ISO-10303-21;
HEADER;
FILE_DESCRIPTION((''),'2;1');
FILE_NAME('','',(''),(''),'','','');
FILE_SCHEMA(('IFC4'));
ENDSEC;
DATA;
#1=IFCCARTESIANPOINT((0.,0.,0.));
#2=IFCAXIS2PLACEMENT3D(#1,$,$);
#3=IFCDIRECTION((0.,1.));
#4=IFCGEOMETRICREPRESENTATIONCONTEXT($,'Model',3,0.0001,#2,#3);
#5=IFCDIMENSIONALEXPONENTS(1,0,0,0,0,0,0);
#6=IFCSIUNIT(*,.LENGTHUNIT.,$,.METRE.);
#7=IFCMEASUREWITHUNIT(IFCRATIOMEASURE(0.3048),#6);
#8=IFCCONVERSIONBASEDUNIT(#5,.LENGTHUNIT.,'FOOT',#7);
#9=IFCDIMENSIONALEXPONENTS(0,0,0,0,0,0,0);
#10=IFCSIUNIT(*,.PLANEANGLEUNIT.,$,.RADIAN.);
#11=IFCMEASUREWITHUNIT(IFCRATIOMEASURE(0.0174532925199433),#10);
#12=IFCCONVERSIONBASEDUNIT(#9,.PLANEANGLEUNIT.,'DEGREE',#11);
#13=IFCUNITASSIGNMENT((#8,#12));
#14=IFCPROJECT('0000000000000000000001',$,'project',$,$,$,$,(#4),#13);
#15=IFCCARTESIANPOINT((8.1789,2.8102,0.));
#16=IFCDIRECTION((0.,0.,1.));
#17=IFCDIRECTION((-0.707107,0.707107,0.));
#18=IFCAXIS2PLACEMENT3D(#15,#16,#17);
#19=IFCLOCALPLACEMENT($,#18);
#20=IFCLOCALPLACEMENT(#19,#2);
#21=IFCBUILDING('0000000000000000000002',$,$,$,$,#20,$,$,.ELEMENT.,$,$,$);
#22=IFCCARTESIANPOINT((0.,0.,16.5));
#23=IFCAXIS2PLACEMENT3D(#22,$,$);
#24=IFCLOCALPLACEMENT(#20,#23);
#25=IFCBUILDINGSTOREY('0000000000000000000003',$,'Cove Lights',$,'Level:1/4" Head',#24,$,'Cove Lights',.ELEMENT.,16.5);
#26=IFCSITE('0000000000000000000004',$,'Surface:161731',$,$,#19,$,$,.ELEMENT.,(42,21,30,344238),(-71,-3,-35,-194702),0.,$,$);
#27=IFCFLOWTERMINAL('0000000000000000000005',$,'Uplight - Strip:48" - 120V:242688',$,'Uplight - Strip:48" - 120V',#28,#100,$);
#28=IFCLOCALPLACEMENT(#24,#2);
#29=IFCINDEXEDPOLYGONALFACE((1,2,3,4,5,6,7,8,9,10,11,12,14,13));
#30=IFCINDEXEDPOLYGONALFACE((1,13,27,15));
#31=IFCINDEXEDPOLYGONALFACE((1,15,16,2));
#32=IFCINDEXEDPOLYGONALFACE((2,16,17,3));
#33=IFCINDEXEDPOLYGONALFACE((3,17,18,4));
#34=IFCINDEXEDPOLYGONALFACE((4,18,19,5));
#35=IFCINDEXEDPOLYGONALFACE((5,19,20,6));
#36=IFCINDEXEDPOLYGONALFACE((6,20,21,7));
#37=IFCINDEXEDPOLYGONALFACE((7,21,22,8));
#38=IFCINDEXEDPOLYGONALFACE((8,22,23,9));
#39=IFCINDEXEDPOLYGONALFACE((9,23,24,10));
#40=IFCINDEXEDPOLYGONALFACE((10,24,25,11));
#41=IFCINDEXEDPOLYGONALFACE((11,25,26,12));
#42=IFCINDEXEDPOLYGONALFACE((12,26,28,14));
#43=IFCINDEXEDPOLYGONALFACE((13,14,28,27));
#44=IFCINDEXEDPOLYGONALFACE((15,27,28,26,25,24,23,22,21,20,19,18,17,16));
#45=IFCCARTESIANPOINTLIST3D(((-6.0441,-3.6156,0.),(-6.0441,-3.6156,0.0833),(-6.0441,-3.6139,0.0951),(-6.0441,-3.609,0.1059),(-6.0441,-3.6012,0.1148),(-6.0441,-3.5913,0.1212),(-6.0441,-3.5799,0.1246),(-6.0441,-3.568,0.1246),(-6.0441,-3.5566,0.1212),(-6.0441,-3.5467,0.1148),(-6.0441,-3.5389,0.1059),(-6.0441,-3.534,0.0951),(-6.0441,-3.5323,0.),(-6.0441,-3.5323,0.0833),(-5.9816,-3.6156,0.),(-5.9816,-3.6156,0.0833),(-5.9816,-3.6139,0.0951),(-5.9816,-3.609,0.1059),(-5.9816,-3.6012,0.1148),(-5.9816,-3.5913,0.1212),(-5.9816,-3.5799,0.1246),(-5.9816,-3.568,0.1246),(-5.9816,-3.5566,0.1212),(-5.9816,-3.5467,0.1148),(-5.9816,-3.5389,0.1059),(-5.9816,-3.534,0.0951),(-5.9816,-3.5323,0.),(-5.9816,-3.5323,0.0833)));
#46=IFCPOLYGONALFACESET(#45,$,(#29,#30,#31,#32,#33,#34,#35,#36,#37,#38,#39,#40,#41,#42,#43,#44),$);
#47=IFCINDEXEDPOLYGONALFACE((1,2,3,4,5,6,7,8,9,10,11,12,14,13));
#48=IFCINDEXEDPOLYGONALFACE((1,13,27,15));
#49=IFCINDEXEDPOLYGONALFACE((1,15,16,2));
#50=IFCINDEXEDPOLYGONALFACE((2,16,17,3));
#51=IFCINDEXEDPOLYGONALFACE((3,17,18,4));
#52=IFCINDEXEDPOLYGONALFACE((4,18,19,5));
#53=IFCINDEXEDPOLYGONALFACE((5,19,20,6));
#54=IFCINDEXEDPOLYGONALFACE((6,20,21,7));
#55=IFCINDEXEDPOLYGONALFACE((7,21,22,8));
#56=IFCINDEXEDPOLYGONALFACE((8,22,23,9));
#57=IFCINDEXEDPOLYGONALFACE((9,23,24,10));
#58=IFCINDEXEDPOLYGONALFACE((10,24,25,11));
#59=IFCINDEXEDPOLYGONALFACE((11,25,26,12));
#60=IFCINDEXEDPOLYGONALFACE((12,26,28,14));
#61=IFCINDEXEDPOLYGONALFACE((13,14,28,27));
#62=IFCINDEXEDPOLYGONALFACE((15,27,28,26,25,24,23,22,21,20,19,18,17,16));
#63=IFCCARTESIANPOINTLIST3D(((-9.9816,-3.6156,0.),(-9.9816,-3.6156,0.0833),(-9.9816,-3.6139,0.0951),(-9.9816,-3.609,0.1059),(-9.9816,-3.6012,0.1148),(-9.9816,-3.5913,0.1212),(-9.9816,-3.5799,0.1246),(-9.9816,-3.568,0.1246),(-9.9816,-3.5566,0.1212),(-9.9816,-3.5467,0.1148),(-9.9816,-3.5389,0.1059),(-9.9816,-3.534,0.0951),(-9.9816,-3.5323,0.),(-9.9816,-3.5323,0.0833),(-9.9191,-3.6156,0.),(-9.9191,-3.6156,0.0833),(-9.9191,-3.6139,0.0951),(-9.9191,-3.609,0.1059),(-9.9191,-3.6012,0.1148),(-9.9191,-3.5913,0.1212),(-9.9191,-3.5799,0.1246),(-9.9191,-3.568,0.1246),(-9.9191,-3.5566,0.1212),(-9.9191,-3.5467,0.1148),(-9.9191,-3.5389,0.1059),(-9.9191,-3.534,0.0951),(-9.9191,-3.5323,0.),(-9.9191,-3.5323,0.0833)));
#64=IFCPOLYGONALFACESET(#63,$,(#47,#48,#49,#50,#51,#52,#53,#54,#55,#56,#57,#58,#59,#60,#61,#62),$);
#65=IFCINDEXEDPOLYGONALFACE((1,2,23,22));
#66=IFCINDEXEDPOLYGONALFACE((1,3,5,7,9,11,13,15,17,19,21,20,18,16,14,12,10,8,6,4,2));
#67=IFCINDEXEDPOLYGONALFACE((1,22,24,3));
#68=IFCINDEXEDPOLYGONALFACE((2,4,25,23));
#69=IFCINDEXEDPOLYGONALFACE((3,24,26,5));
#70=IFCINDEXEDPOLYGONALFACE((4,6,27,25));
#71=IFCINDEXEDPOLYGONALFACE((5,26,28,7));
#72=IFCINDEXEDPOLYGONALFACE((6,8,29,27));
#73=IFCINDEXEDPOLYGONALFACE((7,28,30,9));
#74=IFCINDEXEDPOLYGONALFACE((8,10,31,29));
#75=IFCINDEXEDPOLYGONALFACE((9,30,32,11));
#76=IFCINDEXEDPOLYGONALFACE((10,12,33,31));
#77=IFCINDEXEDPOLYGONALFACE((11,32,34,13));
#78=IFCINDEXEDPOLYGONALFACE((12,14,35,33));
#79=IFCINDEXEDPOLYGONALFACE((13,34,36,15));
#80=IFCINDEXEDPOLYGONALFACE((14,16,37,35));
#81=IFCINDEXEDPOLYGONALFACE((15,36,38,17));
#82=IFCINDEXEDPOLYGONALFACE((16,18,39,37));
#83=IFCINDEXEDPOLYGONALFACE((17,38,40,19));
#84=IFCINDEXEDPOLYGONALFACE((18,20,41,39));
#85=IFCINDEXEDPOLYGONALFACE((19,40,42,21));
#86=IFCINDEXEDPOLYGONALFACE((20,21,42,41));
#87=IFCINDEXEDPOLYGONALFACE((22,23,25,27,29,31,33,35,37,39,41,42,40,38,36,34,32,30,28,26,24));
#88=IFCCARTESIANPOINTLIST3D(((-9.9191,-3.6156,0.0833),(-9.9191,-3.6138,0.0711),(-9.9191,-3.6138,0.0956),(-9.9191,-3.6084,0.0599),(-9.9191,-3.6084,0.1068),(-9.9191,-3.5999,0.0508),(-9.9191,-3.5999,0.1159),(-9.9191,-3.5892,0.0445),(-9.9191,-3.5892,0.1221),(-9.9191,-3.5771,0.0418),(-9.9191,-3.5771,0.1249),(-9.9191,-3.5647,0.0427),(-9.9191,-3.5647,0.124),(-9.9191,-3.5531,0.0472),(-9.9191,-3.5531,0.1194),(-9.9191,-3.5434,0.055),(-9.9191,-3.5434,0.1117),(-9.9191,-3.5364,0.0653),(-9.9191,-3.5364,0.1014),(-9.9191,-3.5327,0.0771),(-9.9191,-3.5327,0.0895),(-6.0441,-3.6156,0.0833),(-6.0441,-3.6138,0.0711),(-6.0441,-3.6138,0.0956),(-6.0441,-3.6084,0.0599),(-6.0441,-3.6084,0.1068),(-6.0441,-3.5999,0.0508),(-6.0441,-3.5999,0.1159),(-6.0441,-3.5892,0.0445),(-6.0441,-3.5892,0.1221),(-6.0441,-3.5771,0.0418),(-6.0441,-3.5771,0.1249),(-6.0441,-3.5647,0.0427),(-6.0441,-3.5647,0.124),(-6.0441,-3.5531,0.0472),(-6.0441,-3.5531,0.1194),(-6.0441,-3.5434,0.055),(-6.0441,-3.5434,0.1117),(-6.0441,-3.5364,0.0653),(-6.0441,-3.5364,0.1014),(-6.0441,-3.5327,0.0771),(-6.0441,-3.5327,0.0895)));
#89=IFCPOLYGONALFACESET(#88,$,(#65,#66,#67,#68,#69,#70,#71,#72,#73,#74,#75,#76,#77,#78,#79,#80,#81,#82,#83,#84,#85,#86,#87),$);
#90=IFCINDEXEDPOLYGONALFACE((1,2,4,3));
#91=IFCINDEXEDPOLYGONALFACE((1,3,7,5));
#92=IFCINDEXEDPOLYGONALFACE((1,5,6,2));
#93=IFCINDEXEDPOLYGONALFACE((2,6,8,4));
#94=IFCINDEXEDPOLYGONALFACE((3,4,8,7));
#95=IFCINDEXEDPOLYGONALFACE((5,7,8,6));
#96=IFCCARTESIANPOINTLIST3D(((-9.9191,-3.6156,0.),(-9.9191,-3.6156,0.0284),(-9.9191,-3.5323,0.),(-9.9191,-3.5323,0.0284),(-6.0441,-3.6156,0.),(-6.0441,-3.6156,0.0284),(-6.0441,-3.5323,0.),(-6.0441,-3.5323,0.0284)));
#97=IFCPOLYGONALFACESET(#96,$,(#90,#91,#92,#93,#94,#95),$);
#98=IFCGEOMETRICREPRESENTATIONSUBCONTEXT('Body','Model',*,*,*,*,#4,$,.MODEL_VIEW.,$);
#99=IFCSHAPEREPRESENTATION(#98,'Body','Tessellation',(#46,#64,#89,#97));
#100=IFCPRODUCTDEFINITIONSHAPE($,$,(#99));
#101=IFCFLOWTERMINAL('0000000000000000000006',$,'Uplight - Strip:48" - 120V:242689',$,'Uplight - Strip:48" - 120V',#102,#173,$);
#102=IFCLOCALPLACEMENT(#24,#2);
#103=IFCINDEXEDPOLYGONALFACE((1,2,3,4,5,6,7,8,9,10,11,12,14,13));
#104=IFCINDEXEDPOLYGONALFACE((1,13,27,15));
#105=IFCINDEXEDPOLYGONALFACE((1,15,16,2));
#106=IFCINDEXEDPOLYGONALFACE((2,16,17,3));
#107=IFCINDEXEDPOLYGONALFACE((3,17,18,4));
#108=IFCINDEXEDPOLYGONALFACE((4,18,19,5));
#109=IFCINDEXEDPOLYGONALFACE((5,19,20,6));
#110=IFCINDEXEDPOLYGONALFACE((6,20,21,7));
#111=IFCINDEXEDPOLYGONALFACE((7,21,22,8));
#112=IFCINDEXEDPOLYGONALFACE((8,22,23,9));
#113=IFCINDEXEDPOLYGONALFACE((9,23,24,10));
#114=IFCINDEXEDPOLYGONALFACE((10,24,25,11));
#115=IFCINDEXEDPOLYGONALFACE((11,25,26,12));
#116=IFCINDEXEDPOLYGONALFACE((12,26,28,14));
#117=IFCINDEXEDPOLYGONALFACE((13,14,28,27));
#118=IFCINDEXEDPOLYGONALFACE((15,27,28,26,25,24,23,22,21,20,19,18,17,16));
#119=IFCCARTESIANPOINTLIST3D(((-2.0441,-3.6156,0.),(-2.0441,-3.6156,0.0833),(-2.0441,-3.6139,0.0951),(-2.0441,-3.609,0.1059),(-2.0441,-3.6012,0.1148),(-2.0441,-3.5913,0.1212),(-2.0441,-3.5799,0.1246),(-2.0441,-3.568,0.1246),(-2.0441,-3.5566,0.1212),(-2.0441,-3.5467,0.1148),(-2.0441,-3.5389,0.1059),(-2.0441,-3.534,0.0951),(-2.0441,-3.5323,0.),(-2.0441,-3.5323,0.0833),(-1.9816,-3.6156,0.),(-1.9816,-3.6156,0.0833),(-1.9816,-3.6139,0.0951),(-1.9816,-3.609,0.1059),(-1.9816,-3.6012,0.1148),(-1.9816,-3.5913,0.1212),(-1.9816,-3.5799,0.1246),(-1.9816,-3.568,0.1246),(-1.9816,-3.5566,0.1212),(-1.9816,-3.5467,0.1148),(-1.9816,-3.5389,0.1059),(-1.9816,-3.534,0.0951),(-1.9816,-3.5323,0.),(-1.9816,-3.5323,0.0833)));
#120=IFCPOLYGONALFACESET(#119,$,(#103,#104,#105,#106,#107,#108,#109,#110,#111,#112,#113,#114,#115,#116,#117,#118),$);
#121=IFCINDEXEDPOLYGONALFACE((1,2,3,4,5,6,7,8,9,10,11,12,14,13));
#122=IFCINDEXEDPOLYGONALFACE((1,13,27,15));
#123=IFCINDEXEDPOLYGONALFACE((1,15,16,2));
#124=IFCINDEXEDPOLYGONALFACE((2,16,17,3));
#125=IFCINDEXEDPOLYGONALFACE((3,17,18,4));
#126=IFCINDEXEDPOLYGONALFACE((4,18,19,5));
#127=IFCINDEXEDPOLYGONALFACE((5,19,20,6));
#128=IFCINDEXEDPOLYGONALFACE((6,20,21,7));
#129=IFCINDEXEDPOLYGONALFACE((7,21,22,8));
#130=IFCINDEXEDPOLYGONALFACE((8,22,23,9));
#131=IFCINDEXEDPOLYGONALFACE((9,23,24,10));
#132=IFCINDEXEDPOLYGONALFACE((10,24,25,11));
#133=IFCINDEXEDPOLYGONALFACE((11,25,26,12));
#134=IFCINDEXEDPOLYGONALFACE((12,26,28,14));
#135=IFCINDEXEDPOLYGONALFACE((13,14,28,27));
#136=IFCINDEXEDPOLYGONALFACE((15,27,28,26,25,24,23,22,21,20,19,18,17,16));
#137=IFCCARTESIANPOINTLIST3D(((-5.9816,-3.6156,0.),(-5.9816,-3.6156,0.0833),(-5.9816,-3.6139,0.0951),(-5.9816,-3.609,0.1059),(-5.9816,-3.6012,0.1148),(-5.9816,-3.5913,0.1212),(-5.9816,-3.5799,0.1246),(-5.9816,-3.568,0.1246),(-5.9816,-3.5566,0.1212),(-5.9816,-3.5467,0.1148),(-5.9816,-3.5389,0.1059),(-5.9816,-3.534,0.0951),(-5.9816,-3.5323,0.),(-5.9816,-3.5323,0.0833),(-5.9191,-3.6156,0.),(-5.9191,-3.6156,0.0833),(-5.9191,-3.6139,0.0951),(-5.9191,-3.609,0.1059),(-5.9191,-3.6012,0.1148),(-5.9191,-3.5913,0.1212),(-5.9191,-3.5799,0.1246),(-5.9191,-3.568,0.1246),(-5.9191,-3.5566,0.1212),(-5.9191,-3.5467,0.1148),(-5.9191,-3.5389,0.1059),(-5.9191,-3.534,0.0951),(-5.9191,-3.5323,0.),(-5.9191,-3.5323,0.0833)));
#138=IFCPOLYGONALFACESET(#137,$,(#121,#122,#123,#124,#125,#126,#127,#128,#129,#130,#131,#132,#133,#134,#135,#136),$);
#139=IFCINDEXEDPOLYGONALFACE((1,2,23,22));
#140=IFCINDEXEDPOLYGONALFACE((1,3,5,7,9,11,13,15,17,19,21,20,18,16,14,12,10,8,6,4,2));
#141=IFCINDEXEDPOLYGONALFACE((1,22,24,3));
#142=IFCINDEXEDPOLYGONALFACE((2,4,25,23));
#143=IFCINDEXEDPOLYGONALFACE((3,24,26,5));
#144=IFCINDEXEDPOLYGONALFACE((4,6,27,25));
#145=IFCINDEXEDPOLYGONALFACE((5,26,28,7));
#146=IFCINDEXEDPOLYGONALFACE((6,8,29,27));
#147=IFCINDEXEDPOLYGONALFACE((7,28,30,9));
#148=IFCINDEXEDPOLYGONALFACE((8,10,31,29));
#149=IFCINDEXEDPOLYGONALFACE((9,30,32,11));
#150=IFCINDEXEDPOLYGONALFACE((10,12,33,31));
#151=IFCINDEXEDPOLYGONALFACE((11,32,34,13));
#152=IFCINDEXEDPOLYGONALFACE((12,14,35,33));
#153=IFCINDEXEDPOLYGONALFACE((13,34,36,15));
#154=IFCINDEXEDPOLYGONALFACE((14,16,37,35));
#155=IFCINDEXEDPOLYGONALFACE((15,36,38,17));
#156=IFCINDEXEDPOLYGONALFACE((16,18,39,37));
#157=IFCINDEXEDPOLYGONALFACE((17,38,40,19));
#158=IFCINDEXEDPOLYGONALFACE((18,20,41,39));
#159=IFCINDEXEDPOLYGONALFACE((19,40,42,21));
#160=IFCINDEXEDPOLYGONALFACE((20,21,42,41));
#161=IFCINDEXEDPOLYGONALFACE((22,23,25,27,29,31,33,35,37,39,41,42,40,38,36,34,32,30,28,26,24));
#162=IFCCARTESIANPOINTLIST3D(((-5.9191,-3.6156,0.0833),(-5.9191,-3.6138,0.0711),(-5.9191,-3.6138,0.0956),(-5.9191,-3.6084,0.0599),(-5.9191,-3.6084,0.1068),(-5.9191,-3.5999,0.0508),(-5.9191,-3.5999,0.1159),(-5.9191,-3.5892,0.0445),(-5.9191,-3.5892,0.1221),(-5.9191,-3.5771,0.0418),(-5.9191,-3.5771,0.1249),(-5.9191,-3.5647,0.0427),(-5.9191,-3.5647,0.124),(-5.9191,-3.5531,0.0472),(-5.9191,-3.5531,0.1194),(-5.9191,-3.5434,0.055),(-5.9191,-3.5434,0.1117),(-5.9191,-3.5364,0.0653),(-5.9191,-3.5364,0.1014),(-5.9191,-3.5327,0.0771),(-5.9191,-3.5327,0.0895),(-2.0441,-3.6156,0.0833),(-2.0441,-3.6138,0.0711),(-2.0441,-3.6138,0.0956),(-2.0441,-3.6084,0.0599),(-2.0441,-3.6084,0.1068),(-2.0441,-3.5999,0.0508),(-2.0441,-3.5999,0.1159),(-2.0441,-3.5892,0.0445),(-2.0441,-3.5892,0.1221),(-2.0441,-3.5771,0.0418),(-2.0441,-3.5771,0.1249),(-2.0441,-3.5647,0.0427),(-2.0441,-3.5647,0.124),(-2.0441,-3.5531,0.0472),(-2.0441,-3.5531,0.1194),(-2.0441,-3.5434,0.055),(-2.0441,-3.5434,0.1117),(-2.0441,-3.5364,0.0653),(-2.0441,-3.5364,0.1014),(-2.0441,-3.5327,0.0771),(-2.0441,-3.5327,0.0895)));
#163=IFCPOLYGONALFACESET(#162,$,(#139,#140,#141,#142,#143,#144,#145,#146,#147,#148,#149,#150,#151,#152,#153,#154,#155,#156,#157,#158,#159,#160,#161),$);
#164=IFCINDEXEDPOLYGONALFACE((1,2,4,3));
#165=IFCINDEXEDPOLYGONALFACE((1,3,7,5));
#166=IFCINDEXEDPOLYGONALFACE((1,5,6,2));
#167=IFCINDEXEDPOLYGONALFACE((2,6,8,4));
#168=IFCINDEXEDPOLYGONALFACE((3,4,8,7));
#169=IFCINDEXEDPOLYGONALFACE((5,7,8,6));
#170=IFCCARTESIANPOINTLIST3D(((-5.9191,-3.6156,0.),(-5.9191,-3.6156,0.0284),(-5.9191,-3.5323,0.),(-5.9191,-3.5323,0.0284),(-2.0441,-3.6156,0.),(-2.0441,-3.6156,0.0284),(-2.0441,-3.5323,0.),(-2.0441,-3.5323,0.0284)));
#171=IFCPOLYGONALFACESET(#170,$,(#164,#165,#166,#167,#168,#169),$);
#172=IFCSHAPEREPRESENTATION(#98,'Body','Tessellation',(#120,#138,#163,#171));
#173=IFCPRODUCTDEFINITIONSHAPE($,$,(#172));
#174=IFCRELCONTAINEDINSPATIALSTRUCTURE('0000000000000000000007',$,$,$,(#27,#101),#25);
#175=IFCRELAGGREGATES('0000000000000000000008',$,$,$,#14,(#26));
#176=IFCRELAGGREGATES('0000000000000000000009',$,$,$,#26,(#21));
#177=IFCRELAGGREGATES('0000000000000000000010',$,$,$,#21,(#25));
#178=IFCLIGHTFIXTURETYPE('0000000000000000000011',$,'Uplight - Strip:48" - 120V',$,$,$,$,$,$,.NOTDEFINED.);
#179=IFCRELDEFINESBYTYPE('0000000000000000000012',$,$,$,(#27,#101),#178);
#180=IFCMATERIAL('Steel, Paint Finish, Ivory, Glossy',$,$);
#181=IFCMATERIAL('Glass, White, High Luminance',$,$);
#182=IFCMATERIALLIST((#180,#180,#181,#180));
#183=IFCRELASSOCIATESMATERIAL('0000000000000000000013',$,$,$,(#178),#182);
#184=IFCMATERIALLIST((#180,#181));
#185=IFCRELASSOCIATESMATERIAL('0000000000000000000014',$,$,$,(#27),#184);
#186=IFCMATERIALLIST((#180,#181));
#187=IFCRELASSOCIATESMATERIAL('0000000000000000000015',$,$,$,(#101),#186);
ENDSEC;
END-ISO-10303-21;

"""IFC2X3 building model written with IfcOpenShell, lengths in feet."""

from ifc_helpers import new_model, entity, si_unit, converted_unit, direction, frame, frame_2d, origin, origin_2d_with_axis, place, context, subcontext, project, spatial, polyline, circle_curve, parameter, trimmed, segment, composite_curve, rectangle, circle, outline, extrude, source, transform, mapped, material, material_list, type_object, type_shapes, element, save


model = new_model("IFC2X3")

# Units and contexts
model_context = context("Model", 3, precision=0.0001, world=origin(), true_north=direction((0.0, 1.0)))
body_context = subcontext(model_context, "Body", "Model", "MODEL_VIEW")
ifc_project = project(units=[converted_unit("LENGTHUNIT", "FOOT", entity("IfcRatioMeasure", 0.3048), si_unit("LENGTHUNIT", "METRE"), dimensions=[1, 0, 0, 0, 0, 0, 0]), converted_unit("PLANEANGLEUNIT", "DEGREE", entity("IfcRatioMeasure", 0.0174532925199433), si_unit("PLANEANGLEUNIT", "RADIAN"), dimensions=[0, 0, 0, 0, 0, 0, 0])], contexts=[model_context])

# Site, building, storey
site_placement = place(None, frame((8.1789, 2.8102, 0.0), z_axis=(0.0, 0.0, 1.0), x_axis=(-0.707107, 0.707107, 0.0)))
site = spatial("IfcSite", under=ifc_project, at=site_placement, Name="Surface:161731", CompositionType="ELEMENT", RefLatitude=(42, 21, 30, 344238), RefLongitude=(-71, -3, -35, -194702), RefElevation=0.0)
building_placement = place(site_placement, origin())
building = spatial("IfcBuilding", under=site, at=building_placement, CompositionType="ELEMENT")
storey_placement = place(building_placement, frame((0.0, 0.0, 16.5)))
storey = spatial("IfcBuildingStorey", under=building, at=storey_placement, Name="Cove Lights", ObjectType="Level:1/4\" Head", LongName="Cove Lights", CompositionType="ELEMENT", Elevation=16.5)

# Flow terminals
ifc_material_1 = material(Name="Steel, Paint Finish, Ivory, Glossy")
ifc_material_2 = material(Name="Glass, White, High Luminance")
ifc_material_list_1 = material_list([ifc_material_1, ifc_material_1, ifc_material_2, ifc_material_1])
light_fixture_type_1 = type_object("IfcLightFixtureType", Name="Uplight - Strip:48\" - 120V", PredefinedType="NOTDEFINED", material=ifc_material_list_1)
shared_shape_1 = source(origin(), body_context, "Body", "SweptSolid", [
    extrude(outline(composite_curve([segment(polyline([(-0.0417, -0.0417), (0.0417, -0.0417)]), True, "CONTINUOUS"), segment(polyline([(0.0417, -0.0417), (0.0417, 0.0417)]), True, "CONTINUOUS"), segment(trimmed(circle_curve(frame_2d((0.0, 0.0417), x_axis=(-1.0, 0.0)), 0.0417), [parameter(180.0)], [parameter(0.0)], True, "PARAMETER"), True, "CONTINUOUS"), segment(polyline([(-0.0417, 0.0417), (-0.0417, -0.0417)]), True, "CONTINUOUS")], self_intersect=False)), frame((1.9375, 0.0, 0.0417), z_axis=(1.0, 0.0, 0.0), x_axis=(0.0, 1.0, 0.0)), (0.0, 0.0, 1.0), 0.0625),
    extrude(outline(composite_curve([segment(polyline([(-0.0417, -0.0417), (0.0417, -0.0417)]), True, "CONTINUOUS"), segment(trimmed(circle_curve(frame_2d((0.0417, 0.0), x_axis=(1.0, 0.0)), 0.0417), [parameter(270.0)], [parameter(90.0)], True, "PARAMETER"), True, "CONTINUOUS"), segment(polyline([(0.0417, 0.0417), (-0.0417, 0.0417)]), True, "CONTINUOUS"), segment(polyline([(-0.0417, 0.0417), (-0.0417, -0.0417)]), True, "CONTINUOUS")], self_intersect=False)), frame((-2.0, 0.0, 0.0417), z_axis=(1.0, 0.0, 0.0), x_axis=(0.0, 0.0, 1.0)), (0.0, 0.0, 1.0), 0.0625),
    extrude(circle(Radius=0.0417, at=frame_2d((0.0, 0.0), x_axis=(1.0, 0.0))), frame((-1.9375, 0.0, 0.0833), z_axis=(1.0, 0.0, 0.0), x_axis=(0.0, -1.0, 0.0)), (0.0, 0.0, 1.0), 3.875),
    extrude(rectangle(XDim=0.0833, YDim=3.875, at=origin_2d_with_axis()), frame((0.0, 0.0, 0.0), z_axis=(0.0, 0.0, 1.0), x_axis=(0.0, 1.0, 0.0)), (0.0, 0.0, 1.0), 0.0284),
])
type_shapes(light_fixture_type_1, [shared_shape_1])
ifc_material_list_2 = material_list([ifc_material_1, ifc_material_2])
flow_terminal_1_placement = place(storey_placement, frame((-7.9816, -3.5739, 0.0)))
element("IfcFlowTerminal", 1, at=flow_terminal_1_placement, inside=storey, type_object=light_fixture_type_1, material=ifc_material_list_2, Name="Uplight - Strip:48\" - 120V:242688", ObjectType="Uplight - Strip:48\" - 120V", context=body_context, shape_type="MappedRepresentation", body=[
    mapped(shared_shape_1, transform((0.0, 0.0, 0.0), scale=1.0)),
])
ifc_material_list_3 = material_list([ifc_material_1, ifc_material_2])
flow_terminal_2_placement = place(storey_placement, frame((-3.9816, -3.5739, 0.0)))
element("IfcFlowTerminal", 2, at=flow_terminal_2_placement, inside=storey, type_object=light_fixture_type_1, material=ifc_material_list_3, Name="Uplight - Strip:48\" - 120V:242689", ObjectType="Uplight - Strip:48\" - 120V", context=body_context, shape_type="MappedRepresentation", body=[
    mapped(shared_shape_1, transform((0.0, 0.0, 0.0), scale=1.0)),
])

save(model, "model.ifc")
